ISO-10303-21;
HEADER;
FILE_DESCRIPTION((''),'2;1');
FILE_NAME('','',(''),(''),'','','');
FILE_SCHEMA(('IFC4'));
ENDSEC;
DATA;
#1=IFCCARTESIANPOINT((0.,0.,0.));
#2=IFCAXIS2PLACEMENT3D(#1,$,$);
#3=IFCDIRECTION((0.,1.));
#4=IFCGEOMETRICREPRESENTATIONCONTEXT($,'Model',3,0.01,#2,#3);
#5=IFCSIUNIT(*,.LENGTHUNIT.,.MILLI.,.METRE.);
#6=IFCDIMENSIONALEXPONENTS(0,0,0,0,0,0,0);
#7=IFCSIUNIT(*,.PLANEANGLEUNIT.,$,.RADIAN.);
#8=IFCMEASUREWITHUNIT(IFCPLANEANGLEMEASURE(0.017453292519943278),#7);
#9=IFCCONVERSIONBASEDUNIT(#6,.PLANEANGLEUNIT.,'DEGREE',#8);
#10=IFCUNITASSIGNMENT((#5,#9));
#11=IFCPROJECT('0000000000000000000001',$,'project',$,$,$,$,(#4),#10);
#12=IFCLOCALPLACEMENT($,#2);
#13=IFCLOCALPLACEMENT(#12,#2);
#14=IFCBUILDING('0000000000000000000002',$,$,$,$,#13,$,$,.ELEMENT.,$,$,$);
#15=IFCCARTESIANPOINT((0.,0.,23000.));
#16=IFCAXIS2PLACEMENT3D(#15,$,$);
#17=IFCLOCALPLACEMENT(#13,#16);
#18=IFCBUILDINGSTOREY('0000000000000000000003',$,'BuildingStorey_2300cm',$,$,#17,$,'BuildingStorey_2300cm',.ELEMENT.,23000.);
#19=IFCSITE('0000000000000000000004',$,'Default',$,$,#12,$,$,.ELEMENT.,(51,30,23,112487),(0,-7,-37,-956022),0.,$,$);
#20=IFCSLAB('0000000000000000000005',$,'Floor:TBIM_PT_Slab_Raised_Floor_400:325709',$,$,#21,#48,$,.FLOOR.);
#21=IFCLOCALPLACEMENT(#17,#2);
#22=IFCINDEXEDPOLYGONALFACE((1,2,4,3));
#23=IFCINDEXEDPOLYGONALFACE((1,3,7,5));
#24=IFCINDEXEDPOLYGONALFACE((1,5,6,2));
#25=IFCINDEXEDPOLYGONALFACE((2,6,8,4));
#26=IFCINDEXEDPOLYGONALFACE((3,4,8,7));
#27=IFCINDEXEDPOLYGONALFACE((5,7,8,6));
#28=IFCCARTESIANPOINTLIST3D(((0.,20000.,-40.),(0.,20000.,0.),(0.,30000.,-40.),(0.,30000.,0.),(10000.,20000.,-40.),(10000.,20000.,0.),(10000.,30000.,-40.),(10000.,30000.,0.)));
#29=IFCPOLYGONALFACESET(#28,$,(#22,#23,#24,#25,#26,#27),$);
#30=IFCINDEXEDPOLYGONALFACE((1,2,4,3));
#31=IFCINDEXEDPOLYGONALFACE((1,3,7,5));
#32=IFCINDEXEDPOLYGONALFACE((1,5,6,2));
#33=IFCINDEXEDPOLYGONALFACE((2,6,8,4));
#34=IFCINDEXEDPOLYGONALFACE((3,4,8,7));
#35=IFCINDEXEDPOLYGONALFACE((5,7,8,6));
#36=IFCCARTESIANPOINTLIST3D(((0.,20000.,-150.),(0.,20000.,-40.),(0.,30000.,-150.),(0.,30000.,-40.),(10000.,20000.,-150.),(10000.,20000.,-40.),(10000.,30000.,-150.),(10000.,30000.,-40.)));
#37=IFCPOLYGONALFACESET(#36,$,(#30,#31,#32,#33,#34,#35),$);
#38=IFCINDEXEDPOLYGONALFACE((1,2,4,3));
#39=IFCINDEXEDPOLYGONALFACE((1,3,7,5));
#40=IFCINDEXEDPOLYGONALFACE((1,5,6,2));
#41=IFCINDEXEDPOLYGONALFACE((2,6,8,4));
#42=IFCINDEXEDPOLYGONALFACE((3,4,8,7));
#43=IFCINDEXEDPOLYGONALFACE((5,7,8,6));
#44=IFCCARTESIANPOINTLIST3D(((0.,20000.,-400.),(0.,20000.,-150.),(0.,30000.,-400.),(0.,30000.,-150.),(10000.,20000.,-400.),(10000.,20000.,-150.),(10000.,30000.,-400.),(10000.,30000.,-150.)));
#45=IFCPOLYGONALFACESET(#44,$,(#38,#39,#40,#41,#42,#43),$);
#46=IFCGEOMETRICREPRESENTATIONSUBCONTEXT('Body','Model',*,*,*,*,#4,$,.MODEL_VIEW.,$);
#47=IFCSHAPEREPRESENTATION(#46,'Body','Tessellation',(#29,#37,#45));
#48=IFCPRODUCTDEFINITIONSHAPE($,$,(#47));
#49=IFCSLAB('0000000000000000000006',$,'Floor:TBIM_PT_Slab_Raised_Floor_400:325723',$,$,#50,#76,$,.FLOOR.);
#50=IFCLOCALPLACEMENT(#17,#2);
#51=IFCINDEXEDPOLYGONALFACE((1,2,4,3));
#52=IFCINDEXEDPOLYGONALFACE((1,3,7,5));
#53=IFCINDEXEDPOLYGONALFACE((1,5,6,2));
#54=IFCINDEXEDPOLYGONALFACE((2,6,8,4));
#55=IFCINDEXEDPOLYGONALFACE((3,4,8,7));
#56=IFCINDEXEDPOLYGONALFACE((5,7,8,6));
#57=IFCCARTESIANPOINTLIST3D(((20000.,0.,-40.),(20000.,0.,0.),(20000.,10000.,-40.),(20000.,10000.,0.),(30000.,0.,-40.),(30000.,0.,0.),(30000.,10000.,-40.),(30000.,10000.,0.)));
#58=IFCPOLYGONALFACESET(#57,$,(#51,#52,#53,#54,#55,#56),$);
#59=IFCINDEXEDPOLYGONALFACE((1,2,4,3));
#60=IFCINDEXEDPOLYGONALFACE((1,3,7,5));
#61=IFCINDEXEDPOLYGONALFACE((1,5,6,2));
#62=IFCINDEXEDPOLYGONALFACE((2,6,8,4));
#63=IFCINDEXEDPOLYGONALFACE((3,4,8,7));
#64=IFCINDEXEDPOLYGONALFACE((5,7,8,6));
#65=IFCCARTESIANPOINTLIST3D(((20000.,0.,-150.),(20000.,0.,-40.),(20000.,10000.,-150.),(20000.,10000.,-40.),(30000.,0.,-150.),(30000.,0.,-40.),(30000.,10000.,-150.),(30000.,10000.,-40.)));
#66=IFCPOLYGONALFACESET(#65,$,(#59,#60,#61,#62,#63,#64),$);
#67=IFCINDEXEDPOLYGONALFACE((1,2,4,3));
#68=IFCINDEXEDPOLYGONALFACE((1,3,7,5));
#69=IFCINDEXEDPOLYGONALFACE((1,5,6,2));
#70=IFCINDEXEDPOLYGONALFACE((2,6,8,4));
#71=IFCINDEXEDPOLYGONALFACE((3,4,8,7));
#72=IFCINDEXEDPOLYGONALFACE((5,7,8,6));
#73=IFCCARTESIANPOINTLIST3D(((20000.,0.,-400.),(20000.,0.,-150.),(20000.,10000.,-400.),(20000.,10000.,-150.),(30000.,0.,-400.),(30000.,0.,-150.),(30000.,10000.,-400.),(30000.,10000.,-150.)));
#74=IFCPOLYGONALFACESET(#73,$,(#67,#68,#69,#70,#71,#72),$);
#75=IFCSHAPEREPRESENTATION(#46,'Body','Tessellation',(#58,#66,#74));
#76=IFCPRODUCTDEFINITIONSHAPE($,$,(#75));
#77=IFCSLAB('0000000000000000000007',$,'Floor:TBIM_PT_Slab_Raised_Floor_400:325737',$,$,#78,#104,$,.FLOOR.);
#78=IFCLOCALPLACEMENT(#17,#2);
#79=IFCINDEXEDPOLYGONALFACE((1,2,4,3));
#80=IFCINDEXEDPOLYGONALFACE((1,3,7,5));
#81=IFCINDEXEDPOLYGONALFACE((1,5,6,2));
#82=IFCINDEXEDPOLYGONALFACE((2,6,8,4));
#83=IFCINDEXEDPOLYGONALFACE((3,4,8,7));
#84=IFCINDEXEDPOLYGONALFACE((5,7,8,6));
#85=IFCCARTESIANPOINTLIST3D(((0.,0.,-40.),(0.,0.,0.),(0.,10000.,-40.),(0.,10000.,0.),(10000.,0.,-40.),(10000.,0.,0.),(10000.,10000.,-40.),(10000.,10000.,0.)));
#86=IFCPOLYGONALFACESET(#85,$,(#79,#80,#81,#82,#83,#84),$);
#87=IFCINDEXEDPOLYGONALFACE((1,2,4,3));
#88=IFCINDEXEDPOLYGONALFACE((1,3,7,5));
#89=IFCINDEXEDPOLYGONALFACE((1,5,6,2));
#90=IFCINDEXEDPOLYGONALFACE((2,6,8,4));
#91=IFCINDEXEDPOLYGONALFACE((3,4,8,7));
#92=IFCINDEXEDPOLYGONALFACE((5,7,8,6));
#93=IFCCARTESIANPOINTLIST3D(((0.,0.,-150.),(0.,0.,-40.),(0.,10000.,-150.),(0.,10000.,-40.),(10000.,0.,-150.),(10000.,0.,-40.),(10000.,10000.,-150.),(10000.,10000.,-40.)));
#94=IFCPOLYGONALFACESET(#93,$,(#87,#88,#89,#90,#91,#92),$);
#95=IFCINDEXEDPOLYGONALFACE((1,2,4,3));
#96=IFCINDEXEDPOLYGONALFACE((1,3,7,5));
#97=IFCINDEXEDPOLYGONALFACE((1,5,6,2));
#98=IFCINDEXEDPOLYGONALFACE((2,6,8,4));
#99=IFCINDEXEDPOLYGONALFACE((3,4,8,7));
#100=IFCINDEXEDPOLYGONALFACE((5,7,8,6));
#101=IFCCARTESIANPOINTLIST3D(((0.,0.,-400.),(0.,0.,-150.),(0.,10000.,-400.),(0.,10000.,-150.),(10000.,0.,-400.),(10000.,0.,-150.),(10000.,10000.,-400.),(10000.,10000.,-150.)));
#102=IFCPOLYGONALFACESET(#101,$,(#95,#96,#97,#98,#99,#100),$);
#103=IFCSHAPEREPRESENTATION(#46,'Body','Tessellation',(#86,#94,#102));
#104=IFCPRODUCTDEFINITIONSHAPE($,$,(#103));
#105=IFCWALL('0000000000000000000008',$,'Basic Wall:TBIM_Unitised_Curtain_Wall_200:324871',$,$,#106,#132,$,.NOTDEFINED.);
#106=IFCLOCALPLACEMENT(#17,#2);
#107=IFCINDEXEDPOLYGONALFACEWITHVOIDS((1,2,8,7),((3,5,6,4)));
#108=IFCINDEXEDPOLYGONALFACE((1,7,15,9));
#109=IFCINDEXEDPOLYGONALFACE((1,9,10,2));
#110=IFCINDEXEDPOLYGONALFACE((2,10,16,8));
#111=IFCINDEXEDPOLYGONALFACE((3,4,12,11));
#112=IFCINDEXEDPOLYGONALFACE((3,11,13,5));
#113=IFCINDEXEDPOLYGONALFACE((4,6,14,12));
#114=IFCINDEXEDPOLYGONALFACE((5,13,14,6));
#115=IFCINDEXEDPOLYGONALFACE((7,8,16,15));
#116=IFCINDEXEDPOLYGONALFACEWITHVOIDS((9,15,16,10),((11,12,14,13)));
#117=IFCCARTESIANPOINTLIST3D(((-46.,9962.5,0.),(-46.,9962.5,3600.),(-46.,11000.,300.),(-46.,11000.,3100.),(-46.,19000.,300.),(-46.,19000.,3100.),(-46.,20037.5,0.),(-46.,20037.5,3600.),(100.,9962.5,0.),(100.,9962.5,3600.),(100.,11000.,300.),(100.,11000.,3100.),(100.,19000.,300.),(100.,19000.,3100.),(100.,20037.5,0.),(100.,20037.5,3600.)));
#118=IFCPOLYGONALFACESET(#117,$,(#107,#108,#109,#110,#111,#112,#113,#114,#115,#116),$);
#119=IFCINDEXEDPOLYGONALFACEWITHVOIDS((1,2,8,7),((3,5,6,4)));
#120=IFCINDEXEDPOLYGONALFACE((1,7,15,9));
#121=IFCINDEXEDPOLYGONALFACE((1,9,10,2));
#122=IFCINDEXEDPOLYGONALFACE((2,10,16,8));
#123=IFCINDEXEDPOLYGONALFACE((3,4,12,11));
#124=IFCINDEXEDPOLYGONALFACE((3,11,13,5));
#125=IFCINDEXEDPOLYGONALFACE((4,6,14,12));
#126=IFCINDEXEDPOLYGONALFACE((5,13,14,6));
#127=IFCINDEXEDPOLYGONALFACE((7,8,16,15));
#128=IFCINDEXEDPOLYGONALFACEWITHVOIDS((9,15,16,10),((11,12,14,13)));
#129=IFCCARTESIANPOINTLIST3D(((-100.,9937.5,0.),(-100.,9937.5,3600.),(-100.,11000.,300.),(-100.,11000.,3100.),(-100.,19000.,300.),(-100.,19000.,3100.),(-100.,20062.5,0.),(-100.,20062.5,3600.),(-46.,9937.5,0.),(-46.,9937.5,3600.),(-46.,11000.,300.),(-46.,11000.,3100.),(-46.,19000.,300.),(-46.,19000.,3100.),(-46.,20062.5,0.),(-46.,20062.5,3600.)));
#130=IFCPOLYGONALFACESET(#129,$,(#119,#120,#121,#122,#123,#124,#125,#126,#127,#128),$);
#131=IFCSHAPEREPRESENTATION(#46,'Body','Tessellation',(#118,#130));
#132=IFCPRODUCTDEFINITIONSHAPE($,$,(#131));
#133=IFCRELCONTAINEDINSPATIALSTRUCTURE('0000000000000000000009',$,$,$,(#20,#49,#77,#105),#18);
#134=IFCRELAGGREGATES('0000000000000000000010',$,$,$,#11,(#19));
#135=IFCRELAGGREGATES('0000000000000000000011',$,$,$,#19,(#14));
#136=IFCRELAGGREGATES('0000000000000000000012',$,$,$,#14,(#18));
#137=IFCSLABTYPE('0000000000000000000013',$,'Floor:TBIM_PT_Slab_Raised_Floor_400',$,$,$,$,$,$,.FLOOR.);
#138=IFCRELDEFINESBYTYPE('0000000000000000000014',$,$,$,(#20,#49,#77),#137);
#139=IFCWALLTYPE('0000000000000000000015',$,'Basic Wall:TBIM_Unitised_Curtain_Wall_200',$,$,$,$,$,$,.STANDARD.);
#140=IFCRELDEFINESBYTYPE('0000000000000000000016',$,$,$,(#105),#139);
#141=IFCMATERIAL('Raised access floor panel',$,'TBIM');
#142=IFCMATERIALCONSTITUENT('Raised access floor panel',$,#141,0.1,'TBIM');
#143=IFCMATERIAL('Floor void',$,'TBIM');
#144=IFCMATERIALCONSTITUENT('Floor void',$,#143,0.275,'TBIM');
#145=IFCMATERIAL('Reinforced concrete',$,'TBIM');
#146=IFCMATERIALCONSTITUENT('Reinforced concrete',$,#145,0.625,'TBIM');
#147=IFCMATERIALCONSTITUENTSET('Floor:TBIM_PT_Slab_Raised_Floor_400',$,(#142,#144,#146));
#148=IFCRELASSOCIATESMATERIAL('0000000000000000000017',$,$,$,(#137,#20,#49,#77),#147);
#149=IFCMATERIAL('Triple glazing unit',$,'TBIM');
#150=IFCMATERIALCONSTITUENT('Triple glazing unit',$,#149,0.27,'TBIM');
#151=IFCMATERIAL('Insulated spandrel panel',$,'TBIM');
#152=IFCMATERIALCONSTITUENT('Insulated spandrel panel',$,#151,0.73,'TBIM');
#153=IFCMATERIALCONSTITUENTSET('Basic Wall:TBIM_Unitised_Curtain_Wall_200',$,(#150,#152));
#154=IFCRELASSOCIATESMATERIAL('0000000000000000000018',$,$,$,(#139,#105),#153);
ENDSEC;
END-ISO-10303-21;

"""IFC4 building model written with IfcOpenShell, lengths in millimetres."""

from ifc_helpers import new_model, entity, si_unit, converted_unit, direction, frame, origin, place, context, subcontext, project, spatial, indexed_curve, outline, extrude, material, constituent, constituent_set, type_object, element, save


model = new_model("IFC4")

# Units and contexts
model_context = context("Model", 3, precision=0.01, world=origin(), true_north=direction((0.0, 1.0)))
body_context = subcontext(model_context, "Body", "Model", "MODEL_VIEW")
ifc_project = project(units=[si_unit("LENGTHUNIT", "METRE", prefix="MILLI"), converted_unit("PLANEANGLEUNIT", "DEGREE", entity("IfcPlaneAngleMeasure", 0.017453292519943278), si_unit("PLANEANGLEUNIT", "RADIAN"), dimensions=[0, 0, 0, 0, 0, 0, 0])], contexts=[model_context])

# Site, building, storey
site_placement = place(None, origin())
site = spatial("IfcSite", under=ifc_project, at=site_placement, Name="Default", CompositionType="ELEMENT", RefLatitude=(51, 30, 23, 112487), RefLongitude=(0, -7, -37, -956022), RefElevation=0.0)
building_placement = place(site_placement, origin())
building = spatial("IfcBuilding", under=site, at=building_placement, CompositionType="ELEMENT")
storey_placement = place(building_placement, frame((0.0, 0.0, 23000.0)))
storey = spatial("IfcBuildingStorey", under=building, at=storey_placement, Name="BuildingStorey_2300cm", LongName="BuildingStorey_2300cm", CompositionType="ELEMENT", Elevation=23000.0)

# Slabs
ifc_material_1 = material(Name="Raised access floor panel", Category="TBIM")
ifc_constituent_1 = constituent(ifc_material_1, Name="Raised access floor panel", Category="TBIM", fraction=0.1)
ifc_material_2 = material(Name="Floor void", Category="TBIM")
ifc_constituent_2 = constituent(ifc_material_2, Name="Floor void", Category="TBIM", fraction=0.275)
ifc_material_3 = material(Name="Reinforced concrete", Category="TBIM")
ifc_constituent_3 = constituent(ifc_material_3, Name="Reinforced concrete", Category="TBIM", fraction=0.625)
ifc_constituent_set_1 = constituent_set(constituents=[ifc_constituent_1, ifc_constituent_2, ifc_constituent_3], Name="Floor:TBIM_PT_Slab_Raised_Floor_400")
slab_type = type_object("IfcSlabType", Name="Floor:TBIM_PT_Slab_Raised_Floor_400", PredefinedType="FLOOR", material=ifc_constituent_set_1)
slab_1_placement = place(storey_placement, origin())
element("IfcSlab", 1, at=slab_1_placement, inside=storey, type_object=slab_type, material=ifc_constituent_set_1, Name="Floor:TBIM_PT_Slab_Raised_Floor_400:325709", PredefinedType="FLOOR", context=body_context, shape_type="SweptSolid", body=[
    extrude(outline(indexed_curve([(-5000.0, -5000.0), (5000.0, -5000.0), (5000.0, 5000.0), (-5000.0, 5000.0), (-5000.0, -5000.0)], self_intersect=False)), frame((5000.0, 25000.0, -40.0), z_axis=(0.0, 0.0, 1.0), x_axis=(-1.0, 0.0, 0.0)), (0.0, 0.0, 1.0), 40.0),
    extrude(outline(indexed_curve([(-5000.0, -5000.0), (5000.0, -5000.0), (5000.0, 5000.0), (-5000.0, 5000.0), (-5000.0, -5000.0)], self_intersect=False)), frame((5000.0, 25000.0, -150.0), z_axis=(0.0, 0.0, 1.0), x_axis=(-1.0, 0.0, 0.0)), (0.0, 0.0, 1.0), 110.0),
    extrude(outline(indexed_curve([(-5000.0, -5000.0), (5000.0, -5000.0), (5000.0, 5000.0), (-5000.0, 5000.0), (-5000.0, -5000.0)], self_intersect=False)), frame((5000.0, 25000.0, -400.0), z_axis=(0.0, 0.0, 1.0), x_axis=(-1.0, 0.0, 0.0)), (0.0, 0.0, 1.0), 250.0),
])
slab_2_placement = place(storey_placement, origin())
element("IfcSlab", 2, at=slab_2_placement, inside=storey, type_object=slab_type, material=ifc_constituent_set_1, Name="Floor:TBIM_PT_Slab_Raised_Floor_400:325723", PredefinedType="FLOOR", context=body_context, shape_type="SweptSolid", body=[
    extrude(outline(indexed_curve([(-5000.0, -5000.0), (5000.0, -5000.0), (5000.0, 5000.0), (-5000.0, 5000.0), (-5000.0, -5000.0)], self_intersect=False)), frame((25000.0, 5000.0, -40.0), z_axis=(0.0, 0.0, 1.0), x_axis=(-1.0, 0.0, 0.0)), (0.0, 0.0, 1.0), 40.0),
    extrude(outline(indexed_curve([(-5000.0, -5000.0), (5000.0, -5000.0), (5000.0, 5000.0), (-5000.0, 5000.0), (-5000.0, -5000.0)], self_intersect=False)), frame((25000.0, 5000.0, -150.0), z_axis=(0.0, 0.0, 1.0), x_axis=(-1.0, 0.0, 0.0)), (0.0, 0.0, 1.0), 110.0),
    extrude(outline(indexed_curve([(-5000.0, -5000.0), (5000.0, -5000.0), (5000.0, 5000.0), (-5000.0, 5000.0), (-5000.0, -5000.0)], self_intersect=False)), frame((25000.0, 5000.0, -400.0), z_axis=(0.0, 0.0, 1.0), x_axis=(-1.0, 0.0, 0.0)), (0.0, 0.0, 1.0), 250.0),
])
slab_3_placement = place(storey_placement, origin())
element("IfcSlab", 3, at=slab_3_placement, inside=storey, type_object=slab_type, material=ifc_constituent_set_1, Name="Floor:TBIM_PT_Slab_Raised_Floor_400:325737", PredefinedType="FLOOR", context=body_context, shape_type="SweptSolid", body=[
    extrude(outline(indexed_curve([(-5000.0, -5000.0), (5000.0, -5000.0), (5000.0, 5000.0), (-5000.0, 5000.0), (-5000.0, -5000.0)], self_intersect=False)), frame((5000.0, 5000.0, -40.0), z_axis=(0.0, 0.0, 1.0), x_axis=(-1.0, 0.0, 0.0)), (0.0, 0.0, 1.0), 40.0),
    extrude(outline(indexed_curve([(-5000.0, -5000.0), (5000.0, -5000.0), (5000.0, 5000.0), (-5000.0, 5000.0), (-5000.0, -5000.0)], self_intersect=False)), frame((5000.0, 5000.0, -150.0), z_axis=(0.0, 0.0, 1.0), x_axis=(-1.0, 0.0, 0.0)), (0.0, 0.0, 1.0), 110.0),
    extrude(outline(indexed_curve([(-5000.0, -5000.0), (5000.0, -5000.0), (5000.0, 5000.0), (-5000.0, 5000.0), (-5000.0, -5000.0)], self_intersect=False)), frame((5000.0, 5000.0, -400.0), z_axis=(0.0, 0.0, 1.0), x_axis=(-1.0, 0.0, 0.0)), (0.0, 0.0, 1.0), 250.0),
])

# Wall, opening
ifc_material_4 = material(Name="Triple glazing unit", Category="TBIM")
ifc_constituent_4 = constituent(ifc_material_4, Name="Triple glazing unit", Category="TBIM", fraction=0.27)
ifc_material_5 = material(Name="Insulated spandrel panel", Category="TBIM")
ifc_constituent_5 = constituent(ifc_material_5, Name="Insulated spandrel panel", Category="TBIM", fraction=0.73)
ifc_constituent_set_2 = constituent_set(constituents=[ifc_constituent_4, ifc_constituent_5], Name="Basic Wall:TBIM_Unitised_Curtain_Wall_200")
wall_type = type_object("IfcWallType", Name="Basic Wall:TBIM_Unitised_Curtain_Wall_200", PredefinedType="STANDARD", material=ifc_constituent_set_2)
wall_1_placement = place(storey_placement, frame((0.0, 9937.5, 0.0), z_axis=(0.0, 0.0, 1.0), x_axis=(0.0, 1.0, 0.0)))
wall_1 = element("IfcWall", 4, at=wall_1_placement, inside=storey, type_object=wall_type, material=ifc_constituent_set_2, Name="Basic Wall:TBIM_Unitised_Curtain_Wall_200:324871", PredefinedType="NOTDEFINED", context=body_context, shape_type="SweptSolid", body=[
    extrude(outline(indexed_curve([(-1800.0, -5037.5), (1800.0, -5037.5), (1800.0, 5037.5), (-1800.0, 5037.5), (-1800.0, -5037.5)], self_intersect=False), holes=[indexed_curve([(1300.0, 4000.0), (1300.0, -4000.0), (-1500.0, -4000.0), (-1500.0, 4000.0), (1300.0, 4000.0)], self_intersect=False)]), frame((5062.5, 46.0, 1800.0), z_axis=(0.0, -1.0, 0.0), x_axis=(0.0, 0.0, 1.0)), (0.0, 0.0, 1.0), 146.0),
    extrude(outline(indexed_curve([(-5062.5, -1800.0), (5062.5, -1800.0), (5062.5, 1800.0), (-5062.5, 1800.0), (-5062.5, -1800.0)], self_intersect=False), holes=[indexed_curve([(-4000.0, 1300.0), (4000.0, 1300.0), (4000.0, -1500.0), (-4000.0, -1500.0), (-4000.0, 1300.0)], self_intersect=False)]), frame((5062.5, 100.0, 1800.0), z_axis=(0.0, -1.0, 0.0), x_axis=(1.0, 0.0, 0.0)), (0.0, 0.0, 1.0), 54.0),
])
opening_1_placement = place(wall_1_placement, frame((1062.5, -100.0, 300.0)))
element("IfcOpeningElement", 5, at=opening_1_placement, cuts=wall_1, PredefinedType="OPENING", context=body_context, shape_type="SweptSolid", body=[
    extrude(outline(indexed_curve([(2800.0, 0.0), (2800.0, 8000.0), (0.0, 8000.0), (0.0, 0.0), (2800.0, 0.0)], self_intersect=False)), frame((0.0, 0.0, 0.0), z_axis=(0.0, 1.0, 0.0), x_axis=(0.0, 0.0, 1.0)), (0.0, 0.0, 1.0), 200.0),
])

save(model, "model.ifc")
